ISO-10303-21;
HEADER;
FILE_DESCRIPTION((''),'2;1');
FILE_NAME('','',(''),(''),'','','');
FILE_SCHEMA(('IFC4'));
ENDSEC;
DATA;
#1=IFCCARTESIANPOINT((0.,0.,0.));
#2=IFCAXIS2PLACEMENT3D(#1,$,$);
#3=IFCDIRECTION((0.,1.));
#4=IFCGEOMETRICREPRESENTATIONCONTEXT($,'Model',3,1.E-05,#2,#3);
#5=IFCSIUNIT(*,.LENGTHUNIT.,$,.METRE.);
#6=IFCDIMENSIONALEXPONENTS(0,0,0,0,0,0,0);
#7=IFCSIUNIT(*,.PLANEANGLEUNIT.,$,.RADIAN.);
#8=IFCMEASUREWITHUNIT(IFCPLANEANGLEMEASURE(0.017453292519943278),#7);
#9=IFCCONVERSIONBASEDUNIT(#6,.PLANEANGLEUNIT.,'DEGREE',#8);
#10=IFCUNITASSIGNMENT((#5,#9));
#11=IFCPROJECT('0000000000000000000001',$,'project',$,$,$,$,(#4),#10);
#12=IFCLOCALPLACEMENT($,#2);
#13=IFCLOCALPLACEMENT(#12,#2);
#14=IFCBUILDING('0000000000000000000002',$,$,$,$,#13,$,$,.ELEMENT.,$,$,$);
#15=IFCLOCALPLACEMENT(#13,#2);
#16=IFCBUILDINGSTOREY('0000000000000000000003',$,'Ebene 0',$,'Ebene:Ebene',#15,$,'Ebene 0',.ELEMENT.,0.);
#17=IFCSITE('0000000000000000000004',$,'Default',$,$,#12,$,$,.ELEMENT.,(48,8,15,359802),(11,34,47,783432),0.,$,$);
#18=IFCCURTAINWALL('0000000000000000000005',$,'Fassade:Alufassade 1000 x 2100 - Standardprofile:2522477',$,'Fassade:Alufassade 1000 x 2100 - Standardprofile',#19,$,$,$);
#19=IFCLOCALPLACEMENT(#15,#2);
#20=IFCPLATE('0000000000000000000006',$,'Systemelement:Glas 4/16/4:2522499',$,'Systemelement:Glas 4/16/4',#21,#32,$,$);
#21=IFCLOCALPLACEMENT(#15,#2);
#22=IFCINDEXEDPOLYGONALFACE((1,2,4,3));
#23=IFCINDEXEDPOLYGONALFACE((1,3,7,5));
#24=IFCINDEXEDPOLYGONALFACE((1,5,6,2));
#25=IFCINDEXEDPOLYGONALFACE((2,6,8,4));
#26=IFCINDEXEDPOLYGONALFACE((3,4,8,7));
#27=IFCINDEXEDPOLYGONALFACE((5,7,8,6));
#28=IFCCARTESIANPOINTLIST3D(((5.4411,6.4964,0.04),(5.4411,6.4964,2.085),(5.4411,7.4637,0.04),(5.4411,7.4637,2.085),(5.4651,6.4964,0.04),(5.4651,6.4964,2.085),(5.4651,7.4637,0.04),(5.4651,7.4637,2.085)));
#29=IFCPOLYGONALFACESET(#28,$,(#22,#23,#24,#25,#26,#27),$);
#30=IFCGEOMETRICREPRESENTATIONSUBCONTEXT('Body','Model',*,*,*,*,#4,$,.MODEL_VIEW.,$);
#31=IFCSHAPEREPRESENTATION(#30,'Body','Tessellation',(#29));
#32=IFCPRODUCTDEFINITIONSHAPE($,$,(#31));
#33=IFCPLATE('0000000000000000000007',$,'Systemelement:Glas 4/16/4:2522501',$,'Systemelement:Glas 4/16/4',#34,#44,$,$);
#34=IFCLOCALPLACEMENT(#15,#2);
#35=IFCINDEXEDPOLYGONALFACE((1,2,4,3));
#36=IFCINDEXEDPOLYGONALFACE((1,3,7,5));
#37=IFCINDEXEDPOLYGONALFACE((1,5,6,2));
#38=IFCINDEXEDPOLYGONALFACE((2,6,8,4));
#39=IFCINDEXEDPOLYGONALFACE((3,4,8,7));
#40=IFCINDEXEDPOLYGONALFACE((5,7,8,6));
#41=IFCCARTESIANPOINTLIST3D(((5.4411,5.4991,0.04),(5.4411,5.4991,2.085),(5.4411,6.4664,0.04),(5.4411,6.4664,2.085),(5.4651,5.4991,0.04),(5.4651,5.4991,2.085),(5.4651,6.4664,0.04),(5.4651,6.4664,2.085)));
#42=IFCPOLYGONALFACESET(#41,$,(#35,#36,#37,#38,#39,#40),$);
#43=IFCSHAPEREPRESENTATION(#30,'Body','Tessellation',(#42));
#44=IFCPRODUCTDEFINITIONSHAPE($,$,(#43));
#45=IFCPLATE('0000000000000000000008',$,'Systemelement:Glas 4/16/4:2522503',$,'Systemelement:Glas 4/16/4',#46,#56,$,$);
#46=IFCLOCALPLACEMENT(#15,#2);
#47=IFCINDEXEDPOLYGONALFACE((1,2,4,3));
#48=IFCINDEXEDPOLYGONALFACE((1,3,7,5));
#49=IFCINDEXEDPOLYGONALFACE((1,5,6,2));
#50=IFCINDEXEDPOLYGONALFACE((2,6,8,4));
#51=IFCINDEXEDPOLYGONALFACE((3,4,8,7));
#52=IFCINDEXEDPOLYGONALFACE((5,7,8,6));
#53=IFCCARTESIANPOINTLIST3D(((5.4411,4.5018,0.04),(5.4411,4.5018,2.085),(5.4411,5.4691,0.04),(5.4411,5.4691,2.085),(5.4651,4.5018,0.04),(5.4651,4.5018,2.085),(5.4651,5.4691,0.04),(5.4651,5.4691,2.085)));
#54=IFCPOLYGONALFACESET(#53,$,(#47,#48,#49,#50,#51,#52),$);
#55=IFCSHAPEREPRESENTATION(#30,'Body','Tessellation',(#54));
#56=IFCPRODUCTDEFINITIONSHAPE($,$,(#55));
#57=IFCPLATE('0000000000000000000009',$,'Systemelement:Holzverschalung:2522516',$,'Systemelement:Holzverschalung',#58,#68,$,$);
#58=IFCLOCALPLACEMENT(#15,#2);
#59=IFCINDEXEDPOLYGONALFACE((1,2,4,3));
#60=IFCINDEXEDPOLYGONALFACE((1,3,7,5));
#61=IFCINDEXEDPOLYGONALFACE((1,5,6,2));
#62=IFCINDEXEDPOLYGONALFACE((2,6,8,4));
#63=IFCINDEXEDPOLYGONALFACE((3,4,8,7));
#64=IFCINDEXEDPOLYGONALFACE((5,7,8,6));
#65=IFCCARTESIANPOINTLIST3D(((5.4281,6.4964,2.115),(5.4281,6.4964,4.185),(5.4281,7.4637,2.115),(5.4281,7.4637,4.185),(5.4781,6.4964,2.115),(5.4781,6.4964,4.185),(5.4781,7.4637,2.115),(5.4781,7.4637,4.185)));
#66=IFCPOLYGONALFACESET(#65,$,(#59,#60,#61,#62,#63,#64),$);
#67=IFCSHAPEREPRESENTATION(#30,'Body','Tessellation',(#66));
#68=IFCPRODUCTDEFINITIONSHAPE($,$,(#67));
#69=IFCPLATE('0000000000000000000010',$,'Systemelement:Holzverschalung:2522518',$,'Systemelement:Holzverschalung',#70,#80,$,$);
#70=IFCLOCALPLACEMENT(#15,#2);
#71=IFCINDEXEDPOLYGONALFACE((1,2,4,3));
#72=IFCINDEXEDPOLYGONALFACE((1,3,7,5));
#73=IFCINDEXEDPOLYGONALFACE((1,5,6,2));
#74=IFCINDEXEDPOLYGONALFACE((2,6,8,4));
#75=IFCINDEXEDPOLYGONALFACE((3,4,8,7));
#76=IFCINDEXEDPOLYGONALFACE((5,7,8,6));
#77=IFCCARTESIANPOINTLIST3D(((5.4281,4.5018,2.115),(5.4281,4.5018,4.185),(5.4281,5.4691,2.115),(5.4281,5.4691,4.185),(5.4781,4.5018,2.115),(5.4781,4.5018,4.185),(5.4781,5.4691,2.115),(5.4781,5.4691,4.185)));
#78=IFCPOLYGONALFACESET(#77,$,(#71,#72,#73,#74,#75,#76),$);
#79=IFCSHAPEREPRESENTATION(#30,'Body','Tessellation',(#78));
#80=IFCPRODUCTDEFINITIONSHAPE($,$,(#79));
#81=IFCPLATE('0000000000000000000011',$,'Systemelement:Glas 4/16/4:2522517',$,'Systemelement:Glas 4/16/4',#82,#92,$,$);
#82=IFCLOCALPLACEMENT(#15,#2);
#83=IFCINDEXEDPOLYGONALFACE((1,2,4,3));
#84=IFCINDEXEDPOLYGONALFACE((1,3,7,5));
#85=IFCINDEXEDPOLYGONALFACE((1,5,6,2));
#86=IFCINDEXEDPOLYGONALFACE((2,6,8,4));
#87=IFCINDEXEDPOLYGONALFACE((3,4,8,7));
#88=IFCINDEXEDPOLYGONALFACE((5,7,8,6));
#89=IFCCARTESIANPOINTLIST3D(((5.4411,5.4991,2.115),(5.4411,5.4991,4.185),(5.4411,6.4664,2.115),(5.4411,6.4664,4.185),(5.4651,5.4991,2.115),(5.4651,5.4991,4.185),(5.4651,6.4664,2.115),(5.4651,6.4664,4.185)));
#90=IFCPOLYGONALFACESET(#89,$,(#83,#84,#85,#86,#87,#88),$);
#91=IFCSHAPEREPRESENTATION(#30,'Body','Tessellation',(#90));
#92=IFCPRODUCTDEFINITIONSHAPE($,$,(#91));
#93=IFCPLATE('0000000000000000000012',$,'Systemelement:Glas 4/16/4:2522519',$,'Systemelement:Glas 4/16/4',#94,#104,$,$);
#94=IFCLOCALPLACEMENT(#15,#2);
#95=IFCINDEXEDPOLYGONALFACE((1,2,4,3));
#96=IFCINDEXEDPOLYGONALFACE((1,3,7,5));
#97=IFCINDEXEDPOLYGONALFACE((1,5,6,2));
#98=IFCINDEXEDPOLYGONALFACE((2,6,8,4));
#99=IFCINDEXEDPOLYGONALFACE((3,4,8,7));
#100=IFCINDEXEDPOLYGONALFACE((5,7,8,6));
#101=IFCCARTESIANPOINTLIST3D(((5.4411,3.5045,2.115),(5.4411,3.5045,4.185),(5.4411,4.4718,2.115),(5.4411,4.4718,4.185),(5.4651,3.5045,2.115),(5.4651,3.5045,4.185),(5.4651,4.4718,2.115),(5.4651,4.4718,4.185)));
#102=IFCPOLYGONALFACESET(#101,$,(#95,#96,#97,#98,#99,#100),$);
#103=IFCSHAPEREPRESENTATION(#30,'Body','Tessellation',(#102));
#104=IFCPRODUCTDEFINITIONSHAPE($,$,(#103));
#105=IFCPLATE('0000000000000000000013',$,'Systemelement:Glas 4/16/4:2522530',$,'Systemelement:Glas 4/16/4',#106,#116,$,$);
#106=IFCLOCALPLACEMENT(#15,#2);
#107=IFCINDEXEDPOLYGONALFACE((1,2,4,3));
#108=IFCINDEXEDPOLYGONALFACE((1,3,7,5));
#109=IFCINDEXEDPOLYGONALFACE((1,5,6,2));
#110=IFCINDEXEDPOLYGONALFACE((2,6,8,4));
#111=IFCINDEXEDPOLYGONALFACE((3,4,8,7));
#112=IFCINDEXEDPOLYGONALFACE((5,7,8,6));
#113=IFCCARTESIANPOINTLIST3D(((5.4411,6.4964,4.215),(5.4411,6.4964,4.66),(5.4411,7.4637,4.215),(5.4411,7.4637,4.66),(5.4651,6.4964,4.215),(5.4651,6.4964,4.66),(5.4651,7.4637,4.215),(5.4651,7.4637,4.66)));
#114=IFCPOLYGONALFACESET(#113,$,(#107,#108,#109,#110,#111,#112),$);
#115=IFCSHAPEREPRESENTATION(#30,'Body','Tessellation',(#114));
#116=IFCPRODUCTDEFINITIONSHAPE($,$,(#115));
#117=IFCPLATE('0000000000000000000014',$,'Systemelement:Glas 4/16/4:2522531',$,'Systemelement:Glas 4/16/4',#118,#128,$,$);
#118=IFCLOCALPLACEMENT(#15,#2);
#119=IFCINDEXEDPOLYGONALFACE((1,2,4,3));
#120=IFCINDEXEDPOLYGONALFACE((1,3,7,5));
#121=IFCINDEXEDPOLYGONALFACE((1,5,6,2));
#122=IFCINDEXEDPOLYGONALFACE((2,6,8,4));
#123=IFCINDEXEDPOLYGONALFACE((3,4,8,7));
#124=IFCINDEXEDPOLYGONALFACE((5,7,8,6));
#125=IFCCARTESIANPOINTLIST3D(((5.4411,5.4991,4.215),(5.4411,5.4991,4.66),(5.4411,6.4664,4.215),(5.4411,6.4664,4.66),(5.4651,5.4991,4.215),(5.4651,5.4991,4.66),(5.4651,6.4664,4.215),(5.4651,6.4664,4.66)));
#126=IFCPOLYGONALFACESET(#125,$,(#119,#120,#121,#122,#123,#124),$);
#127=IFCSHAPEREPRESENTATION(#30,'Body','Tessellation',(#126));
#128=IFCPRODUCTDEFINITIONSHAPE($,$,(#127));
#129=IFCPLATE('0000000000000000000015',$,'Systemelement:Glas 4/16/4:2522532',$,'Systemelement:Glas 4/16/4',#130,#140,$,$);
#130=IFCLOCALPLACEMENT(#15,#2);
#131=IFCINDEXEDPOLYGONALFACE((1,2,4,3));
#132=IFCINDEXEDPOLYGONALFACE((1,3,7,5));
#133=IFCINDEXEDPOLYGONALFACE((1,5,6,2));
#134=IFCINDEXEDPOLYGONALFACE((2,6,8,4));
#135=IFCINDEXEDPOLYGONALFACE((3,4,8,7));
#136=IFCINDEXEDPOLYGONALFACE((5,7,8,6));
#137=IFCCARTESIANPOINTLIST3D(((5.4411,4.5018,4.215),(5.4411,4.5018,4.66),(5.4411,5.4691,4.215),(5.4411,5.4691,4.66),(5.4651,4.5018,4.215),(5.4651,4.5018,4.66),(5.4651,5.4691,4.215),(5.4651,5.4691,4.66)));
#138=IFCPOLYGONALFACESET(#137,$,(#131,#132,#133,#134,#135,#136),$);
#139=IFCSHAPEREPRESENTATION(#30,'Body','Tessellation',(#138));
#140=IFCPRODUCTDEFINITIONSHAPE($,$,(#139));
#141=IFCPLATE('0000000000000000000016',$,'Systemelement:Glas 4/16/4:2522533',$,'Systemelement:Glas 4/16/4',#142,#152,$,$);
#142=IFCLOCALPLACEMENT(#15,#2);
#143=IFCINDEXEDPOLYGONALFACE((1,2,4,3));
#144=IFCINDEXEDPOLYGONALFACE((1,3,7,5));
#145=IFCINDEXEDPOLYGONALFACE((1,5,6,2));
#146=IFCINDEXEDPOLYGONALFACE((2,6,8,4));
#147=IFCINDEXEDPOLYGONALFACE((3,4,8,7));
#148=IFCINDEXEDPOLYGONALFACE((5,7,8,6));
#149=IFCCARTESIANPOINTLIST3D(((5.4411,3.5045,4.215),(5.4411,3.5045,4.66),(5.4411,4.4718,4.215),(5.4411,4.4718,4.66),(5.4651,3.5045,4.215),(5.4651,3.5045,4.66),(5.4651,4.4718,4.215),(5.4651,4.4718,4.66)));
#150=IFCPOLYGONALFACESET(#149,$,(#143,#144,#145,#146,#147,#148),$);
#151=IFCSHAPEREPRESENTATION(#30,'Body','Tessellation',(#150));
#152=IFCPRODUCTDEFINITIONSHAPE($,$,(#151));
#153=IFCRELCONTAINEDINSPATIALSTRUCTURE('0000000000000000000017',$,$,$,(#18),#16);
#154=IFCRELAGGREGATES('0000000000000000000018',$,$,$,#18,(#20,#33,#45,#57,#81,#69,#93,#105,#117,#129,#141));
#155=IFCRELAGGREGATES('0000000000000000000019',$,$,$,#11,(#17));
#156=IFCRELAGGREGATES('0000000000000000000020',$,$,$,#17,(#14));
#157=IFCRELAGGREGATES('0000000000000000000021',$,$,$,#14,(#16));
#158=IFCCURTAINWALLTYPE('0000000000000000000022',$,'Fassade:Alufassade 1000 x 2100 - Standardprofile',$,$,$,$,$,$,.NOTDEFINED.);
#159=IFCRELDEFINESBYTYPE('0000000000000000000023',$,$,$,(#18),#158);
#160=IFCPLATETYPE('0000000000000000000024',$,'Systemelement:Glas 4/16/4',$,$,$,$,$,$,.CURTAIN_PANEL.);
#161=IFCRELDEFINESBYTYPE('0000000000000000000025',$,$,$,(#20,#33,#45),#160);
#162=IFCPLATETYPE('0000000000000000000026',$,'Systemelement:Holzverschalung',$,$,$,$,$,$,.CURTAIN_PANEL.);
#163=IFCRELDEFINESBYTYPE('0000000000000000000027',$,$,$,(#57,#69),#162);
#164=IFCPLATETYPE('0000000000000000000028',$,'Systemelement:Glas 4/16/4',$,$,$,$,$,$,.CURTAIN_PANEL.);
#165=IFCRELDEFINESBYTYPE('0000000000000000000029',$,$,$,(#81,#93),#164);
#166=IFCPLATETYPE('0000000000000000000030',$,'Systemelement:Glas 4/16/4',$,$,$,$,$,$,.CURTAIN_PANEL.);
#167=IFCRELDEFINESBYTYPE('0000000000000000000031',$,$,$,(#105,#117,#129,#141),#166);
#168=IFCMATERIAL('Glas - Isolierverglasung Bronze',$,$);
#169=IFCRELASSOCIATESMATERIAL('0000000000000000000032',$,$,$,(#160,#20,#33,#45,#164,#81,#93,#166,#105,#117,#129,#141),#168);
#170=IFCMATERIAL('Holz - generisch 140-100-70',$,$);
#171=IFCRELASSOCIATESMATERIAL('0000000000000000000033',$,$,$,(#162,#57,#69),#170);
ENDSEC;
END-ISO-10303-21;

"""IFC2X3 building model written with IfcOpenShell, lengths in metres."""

from ifc_helpers import new_model, entity, si_unit, converted_unit, direction, frame, origin, origin_2d_with_axis, place, context, subcontext, project, spatial, rectangle, extrude, source, transform, mapped, material, type_object, type_shapes, element, aggregate, save


model = new_model("IFC2X3")

# Units and contexts
model_context = context("Model", 3, precision=1e-05, world=origin(), true_north=direction((0.0, 1.0)))
body_context = subcontext(model_context, "Body", "Model", "MODEL_VIEW")
ifc_project = project(units=[si_unit("LENGTHUNIT", "METRE"), converted_unit("PLANEANGLEUNIT", "DEGREE", entity("IfcPlaneAngleMeasure", 0.017453292519943278), si_unit("PLANEANGLEUNIT", "RADIAN"), dimensions=[0, 0, 0, 0, 0, 0, 0])], contexts=[model_context])

# Site, building, storey
site_placement = place(None, origin())
site = spatial("IfcSite", under=ifc_project, at=site_placement, Name="Default", CompositionType="ELEMENT", RefLatitude=(48, 8, 15, 359802), RefLongitude=(11, 34, 47, 783432), RefElevation=0.0)
building_placement = place(site_placement, origin())
building = spatial("IfcBuilding", under=site, at=building_placement, CompositionType="ELEMENT")
storey_placement = place(building_placement, origin())
storey = spatial("IfcBuildingStorey", under=building, at=storey_placement, Name="Ebene 0", ObjectType="Ebene:Ebene", LongName="Ebene 0", CompositionType="ELEMENT", Elevation=0.0)

# Curtain wall, plates
curtain_wall_type = type_object("IfcCurtainWallType", Name="Fassade:Alufassade 1000 x 2100 - Standardprofile", PredefinedType="NOTDEFINED")
curtain_wall_placement = place(storey_placement, origin())
curtain_wall = element("IfcCurtainWall", 1, at=curtain_wall_placement, inside=storey, type_object=curtain_wall_type, Name="Fassade:Alufassade 1000 x 2100 - Standardprofile:2522477", ObjectType="Fassade:Alufassade 1000 x 2100 - Standardprofile")
ifc_material_1 = material(Name="Glas - Isolierverglasung Bronze")
plate_type_1 = type_object("IfcPlateType", Name="Systemelement:Glas 4/16/4", PredefinedType="CURTAIN_PANEL", material=ifc_material_1)
shared_shape_1 = source(origin(), body_context, "Body", "SweptSolid", [
    extrude(rectangle(XDim=0.024, YDim=0.9673, at=origin_2d_with_axis()), frame((0.0, 0.0, 0.0), z_axis=(0.0, 0.0, 1.0), x_axis=(0.0, 1.0, 0.0)), (0.0, 0.0, 1.0), 2.045),
])
type_shapes(plate_type_1, [shared_shape_1])
plate_1_placement = place(curtain_wall_placement, frame((5.4531, 6.9801, 0.04), z_axis=(0.0, 0.0, 1.0), x_axis=(0.0, -1.0, 0.0)))
plate_1 = element("IfcPlate", 2, at=plate_1_placement, type_object=plate_type_1, material=ifc_material_1, Name="Systemelement:Glas 4/16/4:2522499", ObjectType="Systemelement:Glas 4/16/4", context=body_context, shape_type="MappedRepresentation", body=[
    mapped(shared_shape_1, transform((0.0, 0.0, 0.0), scale=1.0)),
])
plate_2_placement = place(curtain_wall_placement, frame((5.4531, 5.9828, 0.04), z_axis=(0.0, 0.0, 1.0), x_axis=(0.0, -1.0, 0.0)))
plate_2 = element("IfcPlate", 3, at=plate_2_placement, type_object=plate_type_1, material=ifc_material_1, Name="Systemelement:Glas 4/16/4:2522501", ObjectType="Systemelement:Glas 4/16/4", context=body_context, shape_type="MappedRepresentation", body=[
    mapped(shared_shape_1, transform((0.0, 0.0, 0.0), scale=1.0)),
])
plate_3_placement = place(curtain_wall_placement, frame((5.4531, 4.9855, 0.04), z_axis=(0.0, 0.0, 1.0), x_axis=(0.0, -1.0, 0.0)))
plate_3 = element("IfcPlate", 4, at=plate_3_placement, type_object=plate_type_1, material=ifc_material_1, Name="Systemelement:Glas 4/16/4:2522503", ObjectType="Systemelement:Glas 4/16/4", context=body_context, shape_type="MappedRepresentation", body=[
    mapped(shared_shape_1, transform((0.0, 0.0, 0.0), scale=1.0)),
])
ifc_material_2 = material(Name="Holz - generisch 140-100-70")
plate_type_2 = type_object("IfcPlateType", Name="Systemelement:Holzverschalung", PredefinedType="CURTAIN_PANEL", material=ifc_material_2)
shared_shape_2 = source(origin(), body_context, "Body", "SweptSolid", [
    extrude(rectangle(XDim=0.05, YDim=0.9673, at=origin_2d_with_axis()), frame((0.0, 0.0, 0.0), z_axis=(0.0, 0.0, 1.0), x_axis=(0.0, 1.0, 0.0)), (0.0, 0.0, 1.0), 2.07),
])
type_shapes(plate_type_2, [shared_shape_2])
plate_4_placement = place(curtain_wall_placement, frame((5.4531, 6.9801, 2.115), z_axis=(0.0, 0.0, 1.0), x_axis=(0.0, -1.0, 0.0)))
plate_4 = element("IfcPlate", 5, at=plate_4_placement, type_object=plate_type_2, material=ifc_material_2, Name="Systemelement:Holzverschalung:2522516", ObjectType="Systemelement:Holzverschalung", context=body_context, shape_type="MappedRepresentation", body=[
    mapped(shared_shape_2, transform((0.0, 0.0, 0.0), scale=1.0)),
])
plate_5_placement = place(curtain_wall_placement, frame((5.4531, 4.9855, 2.115), z_axis=(0.0, 0.0, 1.0), x_axis=(0.0, -1.0, 0.0)))
plate_5 = element("IfcPlate", 6, at=plate_5_placement, type_object=plate_type_2, material=ifc_material_2, Name="Systemelement:Holzverschalung:2522518", ObjectType="Systemelement:Holzverschalung", context=body_context, shape_type="MappedRepresentation", body=[
    mapped(shared_shape_2, transform((0.0, 0.0, 0.0), scale=1.0)),
])
plate_type_3 = type_object("IfcPlateType", Name="Systemelement:Glas 4/16/4", PredefinedType="CURTAIN_PANEL", material=ifc_material_1)
shared_shape_3 = source(origin(), body_context, "Body", "SweptSolid", [
    extrude(rectangle(XDim=0.024, YDim=0.9673, at=origin_2d_with_axis()), frame((0.0, 0.0, 0.0), z_axis=(0.0, 0.0, 1.0), x_axis=(0.0, 1.0, 0.0)), (0.0, 0.0, 1.0), 2.07),
])
type_shapes(plate_type_3, [shared_shape_3])
plate_6_placement = place(curtain_wall_placement, frame((5.4531, 5.9828, 2.115), z_axis=(0.0, 0.0, 1.0), x_axis=(0.0, -1.0, 0.0)))
plate_6 = element("IfcPlate", 7, at=plate_6_placement, type_object=plate_type_3, material=ifc_material_1, Name="Systemelement:Glas 4/16/4:2522517", ObjectType="Systemelement:Glas 4/16/4", context=body_context, shape_type="MappedRepresentation", body=[
    mapped(shared_shape_3, transform((0.0, 0.0, 0.0), scale=1.0)),
])
plate_7_placement = place(curtain_wall_placement, frame((5.4531, 3.9882, 2.115), z_axis=(0.0, 0.0, 1.0), x_axis=(0.0, -1.0, 0.0)))
plate_7 = element("IfcPlate", 8, at=plate_7_placement, type_object=plate_type_3, material=ifc_material_1, Name="Systemelement:Glas 4/16/4:2522519", ObjectType="Systemelement:Glas 4/16/4", context=body_context, shape_type="MappedRepresentation", body=[
    mapped(shared_shape_3, transform((0.0, 0.0, 0.0), scale=1.0)),
])
plate_type_4 = type_object("IfcPlateType", Name="Systemelement:Glas 4/16/4", PredefinedType="CURTAIN_PANEL", material=ifc_material_1)
shared_shape_4 = source(origin(), body_context, "Body", "SweptSolid", [
    extrude(rectangle(XDim=0.024, YDim=0.9673, at=origin_2d_with_axis()), frame((0.0, 0.0, 0.0), z_axis=(0.0, 0.0, 1.0), x_axis=(0.0, 1.0, 0.0)), (0.0, 0.0, 1.0), 0.445),
])
type_shapes(plate_type_4, [shared_shape_4])
plate_8_placement = place(curtain_wall_placement, frame((5.4531, 6.9801, 4.215), z_axis=(0.0, 0.0, 1.0), x_axis=(0.0, -1.0, 0.0)))
plate_8 = element("IfcPlate", 9, at=plate_8_placement, type_object=plate_type_4, material=ifc_material_1, Name="Systemelement:Glas 4/16/4:2522530", ObjectType="Systemelement:Glas 4/16/4", context=body_context, shape_type="MappedRepresentation", body=[
    mapped(shared_shape_4, transform((0.0, 0.0, 0.0), scale=1.0)),
])
plate_9_placement = place(curtain_wall_placement, frame((5.4531, 5.9828, 4.215), z_axis=(0.0, 0.0, 1.0), x_axis=(0.0, -1.0, 0.0)))
plate_9 = element("IfcPlate", 10, at=plate_9_placement, type_object=plate_type_4, material=ifc_material_1, Name="Systemelement:Glas 4/16/4:2522531", ObjectType="Systemelement:Glas 4/16/4", context=body_context, shape_type="MappedRepresentation", body=[
    mapped(shared_shape_4, transform((0.0, 0.0, 0.0), scale=1.0)),
])
plate_10_placement = place(curtain_wall_placement, frame((5.4531, 4.9855, 4.215), z_axis=(0.0, 0.0, 1.0), x_axis=(0.0, -1.0, 0.0)))
plate_10 = element("IfcPlate", 11, at=plate_10_placement, type_object=plate_type_4, material=ifc_material_1, Name="Systemelement:Glas 4/16/4:2522532", ObjectType="Systemelement:Glas 4/16/4", context=body_context, shape_type="MappedRepresentation", body=[
    mapped(shared_shape_4, transform((0.0, 0.0, 0.0), scale=1.0)),
])
plate_11_placement = place(curtain_wall_placement, frame((5.4531, 3.9882, 4.215), z_axis=(0.0, 0.0, 1.0), x_axis=(0.0, -1.0, 0.0)))
plate_11 = element("IfcPlate", 12, at=plate_11_placement, type_object=plate_type_4, material=ifc_material_1, Name="Systemelement:Glas 4/16/4:2522533", ObjectType="Systemelement:Glas 4/16/4", context=body_context, shape_type="MappedRepresentation", body=[
    mapped(shared_shape_4, transform((0.0, 0.0, 0.0), scale=1.0)),
])
aggregate(curtain_wall, [plate_1, plate_2, plate_3, plate_4, plate_6, plate_5, plate_7, plate_8, plate_9, plate_10, plate_11])

save(model, "model.ifc")
